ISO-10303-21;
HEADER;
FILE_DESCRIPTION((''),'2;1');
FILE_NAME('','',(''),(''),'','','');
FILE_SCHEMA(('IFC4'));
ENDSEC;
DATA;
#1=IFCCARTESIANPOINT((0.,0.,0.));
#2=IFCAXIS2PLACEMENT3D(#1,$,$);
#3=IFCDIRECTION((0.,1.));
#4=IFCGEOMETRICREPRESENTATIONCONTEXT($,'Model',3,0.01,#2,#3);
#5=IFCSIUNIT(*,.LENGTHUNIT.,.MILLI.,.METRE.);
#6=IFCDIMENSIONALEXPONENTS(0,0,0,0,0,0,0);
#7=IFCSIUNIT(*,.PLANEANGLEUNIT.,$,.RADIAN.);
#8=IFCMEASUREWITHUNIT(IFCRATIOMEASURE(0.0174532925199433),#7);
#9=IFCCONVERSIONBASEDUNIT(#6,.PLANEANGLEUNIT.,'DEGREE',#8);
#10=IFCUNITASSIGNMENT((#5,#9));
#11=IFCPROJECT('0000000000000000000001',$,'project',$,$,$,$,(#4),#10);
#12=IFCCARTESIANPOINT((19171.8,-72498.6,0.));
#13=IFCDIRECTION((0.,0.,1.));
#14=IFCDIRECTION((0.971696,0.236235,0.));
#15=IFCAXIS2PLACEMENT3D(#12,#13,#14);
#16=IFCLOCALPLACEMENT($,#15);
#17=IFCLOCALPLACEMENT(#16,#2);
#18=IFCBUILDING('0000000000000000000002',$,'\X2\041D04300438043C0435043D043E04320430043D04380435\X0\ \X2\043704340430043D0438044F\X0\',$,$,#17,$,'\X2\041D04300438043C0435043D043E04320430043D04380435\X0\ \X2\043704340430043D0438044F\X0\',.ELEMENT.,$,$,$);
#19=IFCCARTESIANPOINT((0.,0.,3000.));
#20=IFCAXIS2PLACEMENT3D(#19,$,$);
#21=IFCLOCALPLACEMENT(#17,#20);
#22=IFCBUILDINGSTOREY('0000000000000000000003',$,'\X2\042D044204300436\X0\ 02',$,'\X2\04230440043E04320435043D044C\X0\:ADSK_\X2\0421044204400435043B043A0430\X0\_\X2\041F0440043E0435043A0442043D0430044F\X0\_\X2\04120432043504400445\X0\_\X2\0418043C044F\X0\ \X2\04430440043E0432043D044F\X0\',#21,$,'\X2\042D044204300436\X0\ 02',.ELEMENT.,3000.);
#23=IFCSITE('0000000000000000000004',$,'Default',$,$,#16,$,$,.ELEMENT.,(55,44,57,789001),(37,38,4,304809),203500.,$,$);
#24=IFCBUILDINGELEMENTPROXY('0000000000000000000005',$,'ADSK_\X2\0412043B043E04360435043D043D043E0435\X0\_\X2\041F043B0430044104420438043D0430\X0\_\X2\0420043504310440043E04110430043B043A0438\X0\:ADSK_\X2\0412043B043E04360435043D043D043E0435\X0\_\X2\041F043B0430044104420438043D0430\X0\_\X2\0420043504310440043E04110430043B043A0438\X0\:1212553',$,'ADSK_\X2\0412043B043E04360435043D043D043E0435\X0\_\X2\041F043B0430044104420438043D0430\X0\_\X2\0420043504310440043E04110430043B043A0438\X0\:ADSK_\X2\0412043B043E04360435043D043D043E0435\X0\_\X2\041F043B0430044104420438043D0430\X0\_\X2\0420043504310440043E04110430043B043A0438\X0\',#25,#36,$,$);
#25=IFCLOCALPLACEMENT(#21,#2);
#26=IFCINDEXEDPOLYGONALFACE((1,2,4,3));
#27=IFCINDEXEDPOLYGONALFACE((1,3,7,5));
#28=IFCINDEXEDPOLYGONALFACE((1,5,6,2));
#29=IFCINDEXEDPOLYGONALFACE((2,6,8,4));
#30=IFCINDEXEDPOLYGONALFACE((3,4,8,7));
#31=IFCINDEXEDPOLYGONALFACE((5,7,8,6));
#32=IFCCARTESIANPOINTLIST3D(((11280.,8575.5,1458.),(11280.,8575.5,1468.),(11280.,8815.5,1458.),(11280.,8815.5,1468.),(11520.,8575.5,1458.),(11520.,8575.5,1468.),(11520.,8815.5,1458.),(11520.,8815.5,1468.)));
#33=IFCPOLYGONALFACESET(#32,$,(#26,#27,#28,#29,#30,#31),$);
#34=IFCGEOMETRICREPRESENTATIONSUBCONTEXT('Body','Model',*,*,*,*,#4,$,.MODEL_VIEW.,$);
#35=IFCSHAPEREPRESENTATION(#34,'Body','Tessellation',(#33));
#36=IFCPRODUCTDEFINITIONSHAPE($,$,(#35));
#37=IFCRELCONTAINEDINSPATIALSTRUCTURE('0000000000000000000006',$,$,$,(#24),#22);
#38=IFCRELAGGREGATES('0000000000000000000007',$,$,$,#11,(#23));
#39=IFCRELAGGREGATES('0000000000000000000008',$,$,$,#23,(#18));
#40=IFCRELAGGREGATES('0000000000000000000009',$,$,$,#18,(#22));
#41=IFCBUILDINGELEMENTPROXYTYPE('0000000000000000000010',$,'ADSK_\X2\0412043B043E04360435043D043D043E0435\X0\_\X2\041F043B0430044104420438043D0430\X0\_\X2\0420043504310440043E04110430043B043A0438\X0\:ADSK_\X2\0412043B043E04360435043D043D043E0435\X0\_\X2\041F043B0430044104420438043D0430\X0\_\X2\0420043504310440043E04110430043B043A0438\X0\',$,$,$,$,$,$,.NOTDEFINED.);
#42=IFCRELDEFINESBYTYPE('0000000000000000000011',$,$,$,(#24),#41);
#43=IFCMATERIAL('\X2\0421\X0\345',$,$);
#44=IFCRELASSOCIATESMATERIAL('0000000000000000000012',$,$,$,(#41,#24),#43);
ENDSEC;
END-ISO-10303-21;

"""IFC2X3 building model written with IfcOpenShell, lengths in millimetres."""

from ifc_helpers import new_model, entity, si_unit, converted_unit, direction, frame, origin, origin_2d_with_axis, place, context, subcontext, project, spatial, rectangle, extrude, source, transform, mapped, material, type_object, type_shapes, element, save


model = new_model("IFC2X3")

# Units and contexts
model_context = context("Model", 3, precision=0.01, world=origin(), true_north=direction((0.0, 1.0)))
body_context = subcontext(model_context, "Body", "Model", "MODEL_VIEW")
ifc_project = project(units=[si_unit("LENGTHUNIT", "METRE", prefix="MILLI"), converted_unit("PLANEANGLEUNIT", "DEGREE", entity("IfcRatioMeasure", 0.0174532925199433), si_unit("PLANEANGLEUNIT", "RADIAN"), dimensions=[0, 0, 0, 0, 0, 0, 0])], contexts=[model_context])

# Site, building, storey
site_placement = place(None, frame((19171.8, -72498.6, 0.0), z_axis=(0.0, 0.0, 1.0), x_axis=(0.971696, 0.236235, 0.0)))
site = spatial("IfcSite", under=ifc_project, at=site_placement, Name="Default", CompositionType="ELEMENT", RefLatitude=(55, 44, 57, 789001), RefLongitude=(37, 38, 4, 304809), RefElevation=203500.0)
building_placement = place(site_placement, origin())
building = spatial("IfcBuilding", under=site, at=building_placement, Name="Наименование здания", LongName="Наименование здания", CompositionType="ELEMENT")
storey_placement = place(building_placement, frame((0.0, 0.0, 3000.0)))
storey = spatial("IfcBuildingStorey", under=building, at=storey_placement, Name="Этаж 02", ObjectType="Уровень:ADSK_Стрелка_Проектная_Вверх_Имя уровня", LongName="Этаж 02", CompositionType="ELEMENT", Elevation=3000.0)

# Shared definitions
ifc_material_1 = material(Name="С345")

# Building element proxy
building_element_proxy_type = type_object("IfcBuildingElementProxyType", Name="ADSK_Вложенное_Пластина_РеброБалки:ADSK_Вложенное_Пластина_РеброБалки", PredefinedType="NOTDEFINED", material=ifc_material_1)
shared_shape_1 = source(origin(), body_context, "Body", "SweptSolid", [
    extrude(rectangle(XDim=10.0, YDim=240.0, at=origin_2d_with_axis()), frame((0.0, 0.0, -120.0), z_axis=(0.0, 0.0, 1.0), x_axis=(0.0, 1.0, 0.0)), (0.0, 0.0, 1.0), 240.0),
])
type_shapes(building_element_proxy_type, [shared_shape_1])
for number, where, z_axis, x_axis, name in (
    (1, (11400.0, 8695.5, 1463.0), (0.0, 1.0, 0.0), (1.0, 0.0, 0.0), "ADSK_Вложенное_Пластина_РеброБалки:ADSK_Вложенное_Пластина_РеброБалки:1212553"),
):
    element("IfcBuildingElementProxy", number, at=place(storey_placement, frame(where, z_axis=z_axis, x_axis=x_axis)), inside=storey, type_object=building_element_proxy_type, material=ifc_material_1, Name=name, ObjectType="ADSK_Вложенное_Пластина_РеброБалки:ADSK_Вложенное_Пластина_РеброБалки", context=body_context, shape_type="MappedRepresentation", body=[
        mapped(shared_shape_1, transform((0.0, 0.0, 0.0), scale=1.0)),
    ])

save(model, "model.ifc")
